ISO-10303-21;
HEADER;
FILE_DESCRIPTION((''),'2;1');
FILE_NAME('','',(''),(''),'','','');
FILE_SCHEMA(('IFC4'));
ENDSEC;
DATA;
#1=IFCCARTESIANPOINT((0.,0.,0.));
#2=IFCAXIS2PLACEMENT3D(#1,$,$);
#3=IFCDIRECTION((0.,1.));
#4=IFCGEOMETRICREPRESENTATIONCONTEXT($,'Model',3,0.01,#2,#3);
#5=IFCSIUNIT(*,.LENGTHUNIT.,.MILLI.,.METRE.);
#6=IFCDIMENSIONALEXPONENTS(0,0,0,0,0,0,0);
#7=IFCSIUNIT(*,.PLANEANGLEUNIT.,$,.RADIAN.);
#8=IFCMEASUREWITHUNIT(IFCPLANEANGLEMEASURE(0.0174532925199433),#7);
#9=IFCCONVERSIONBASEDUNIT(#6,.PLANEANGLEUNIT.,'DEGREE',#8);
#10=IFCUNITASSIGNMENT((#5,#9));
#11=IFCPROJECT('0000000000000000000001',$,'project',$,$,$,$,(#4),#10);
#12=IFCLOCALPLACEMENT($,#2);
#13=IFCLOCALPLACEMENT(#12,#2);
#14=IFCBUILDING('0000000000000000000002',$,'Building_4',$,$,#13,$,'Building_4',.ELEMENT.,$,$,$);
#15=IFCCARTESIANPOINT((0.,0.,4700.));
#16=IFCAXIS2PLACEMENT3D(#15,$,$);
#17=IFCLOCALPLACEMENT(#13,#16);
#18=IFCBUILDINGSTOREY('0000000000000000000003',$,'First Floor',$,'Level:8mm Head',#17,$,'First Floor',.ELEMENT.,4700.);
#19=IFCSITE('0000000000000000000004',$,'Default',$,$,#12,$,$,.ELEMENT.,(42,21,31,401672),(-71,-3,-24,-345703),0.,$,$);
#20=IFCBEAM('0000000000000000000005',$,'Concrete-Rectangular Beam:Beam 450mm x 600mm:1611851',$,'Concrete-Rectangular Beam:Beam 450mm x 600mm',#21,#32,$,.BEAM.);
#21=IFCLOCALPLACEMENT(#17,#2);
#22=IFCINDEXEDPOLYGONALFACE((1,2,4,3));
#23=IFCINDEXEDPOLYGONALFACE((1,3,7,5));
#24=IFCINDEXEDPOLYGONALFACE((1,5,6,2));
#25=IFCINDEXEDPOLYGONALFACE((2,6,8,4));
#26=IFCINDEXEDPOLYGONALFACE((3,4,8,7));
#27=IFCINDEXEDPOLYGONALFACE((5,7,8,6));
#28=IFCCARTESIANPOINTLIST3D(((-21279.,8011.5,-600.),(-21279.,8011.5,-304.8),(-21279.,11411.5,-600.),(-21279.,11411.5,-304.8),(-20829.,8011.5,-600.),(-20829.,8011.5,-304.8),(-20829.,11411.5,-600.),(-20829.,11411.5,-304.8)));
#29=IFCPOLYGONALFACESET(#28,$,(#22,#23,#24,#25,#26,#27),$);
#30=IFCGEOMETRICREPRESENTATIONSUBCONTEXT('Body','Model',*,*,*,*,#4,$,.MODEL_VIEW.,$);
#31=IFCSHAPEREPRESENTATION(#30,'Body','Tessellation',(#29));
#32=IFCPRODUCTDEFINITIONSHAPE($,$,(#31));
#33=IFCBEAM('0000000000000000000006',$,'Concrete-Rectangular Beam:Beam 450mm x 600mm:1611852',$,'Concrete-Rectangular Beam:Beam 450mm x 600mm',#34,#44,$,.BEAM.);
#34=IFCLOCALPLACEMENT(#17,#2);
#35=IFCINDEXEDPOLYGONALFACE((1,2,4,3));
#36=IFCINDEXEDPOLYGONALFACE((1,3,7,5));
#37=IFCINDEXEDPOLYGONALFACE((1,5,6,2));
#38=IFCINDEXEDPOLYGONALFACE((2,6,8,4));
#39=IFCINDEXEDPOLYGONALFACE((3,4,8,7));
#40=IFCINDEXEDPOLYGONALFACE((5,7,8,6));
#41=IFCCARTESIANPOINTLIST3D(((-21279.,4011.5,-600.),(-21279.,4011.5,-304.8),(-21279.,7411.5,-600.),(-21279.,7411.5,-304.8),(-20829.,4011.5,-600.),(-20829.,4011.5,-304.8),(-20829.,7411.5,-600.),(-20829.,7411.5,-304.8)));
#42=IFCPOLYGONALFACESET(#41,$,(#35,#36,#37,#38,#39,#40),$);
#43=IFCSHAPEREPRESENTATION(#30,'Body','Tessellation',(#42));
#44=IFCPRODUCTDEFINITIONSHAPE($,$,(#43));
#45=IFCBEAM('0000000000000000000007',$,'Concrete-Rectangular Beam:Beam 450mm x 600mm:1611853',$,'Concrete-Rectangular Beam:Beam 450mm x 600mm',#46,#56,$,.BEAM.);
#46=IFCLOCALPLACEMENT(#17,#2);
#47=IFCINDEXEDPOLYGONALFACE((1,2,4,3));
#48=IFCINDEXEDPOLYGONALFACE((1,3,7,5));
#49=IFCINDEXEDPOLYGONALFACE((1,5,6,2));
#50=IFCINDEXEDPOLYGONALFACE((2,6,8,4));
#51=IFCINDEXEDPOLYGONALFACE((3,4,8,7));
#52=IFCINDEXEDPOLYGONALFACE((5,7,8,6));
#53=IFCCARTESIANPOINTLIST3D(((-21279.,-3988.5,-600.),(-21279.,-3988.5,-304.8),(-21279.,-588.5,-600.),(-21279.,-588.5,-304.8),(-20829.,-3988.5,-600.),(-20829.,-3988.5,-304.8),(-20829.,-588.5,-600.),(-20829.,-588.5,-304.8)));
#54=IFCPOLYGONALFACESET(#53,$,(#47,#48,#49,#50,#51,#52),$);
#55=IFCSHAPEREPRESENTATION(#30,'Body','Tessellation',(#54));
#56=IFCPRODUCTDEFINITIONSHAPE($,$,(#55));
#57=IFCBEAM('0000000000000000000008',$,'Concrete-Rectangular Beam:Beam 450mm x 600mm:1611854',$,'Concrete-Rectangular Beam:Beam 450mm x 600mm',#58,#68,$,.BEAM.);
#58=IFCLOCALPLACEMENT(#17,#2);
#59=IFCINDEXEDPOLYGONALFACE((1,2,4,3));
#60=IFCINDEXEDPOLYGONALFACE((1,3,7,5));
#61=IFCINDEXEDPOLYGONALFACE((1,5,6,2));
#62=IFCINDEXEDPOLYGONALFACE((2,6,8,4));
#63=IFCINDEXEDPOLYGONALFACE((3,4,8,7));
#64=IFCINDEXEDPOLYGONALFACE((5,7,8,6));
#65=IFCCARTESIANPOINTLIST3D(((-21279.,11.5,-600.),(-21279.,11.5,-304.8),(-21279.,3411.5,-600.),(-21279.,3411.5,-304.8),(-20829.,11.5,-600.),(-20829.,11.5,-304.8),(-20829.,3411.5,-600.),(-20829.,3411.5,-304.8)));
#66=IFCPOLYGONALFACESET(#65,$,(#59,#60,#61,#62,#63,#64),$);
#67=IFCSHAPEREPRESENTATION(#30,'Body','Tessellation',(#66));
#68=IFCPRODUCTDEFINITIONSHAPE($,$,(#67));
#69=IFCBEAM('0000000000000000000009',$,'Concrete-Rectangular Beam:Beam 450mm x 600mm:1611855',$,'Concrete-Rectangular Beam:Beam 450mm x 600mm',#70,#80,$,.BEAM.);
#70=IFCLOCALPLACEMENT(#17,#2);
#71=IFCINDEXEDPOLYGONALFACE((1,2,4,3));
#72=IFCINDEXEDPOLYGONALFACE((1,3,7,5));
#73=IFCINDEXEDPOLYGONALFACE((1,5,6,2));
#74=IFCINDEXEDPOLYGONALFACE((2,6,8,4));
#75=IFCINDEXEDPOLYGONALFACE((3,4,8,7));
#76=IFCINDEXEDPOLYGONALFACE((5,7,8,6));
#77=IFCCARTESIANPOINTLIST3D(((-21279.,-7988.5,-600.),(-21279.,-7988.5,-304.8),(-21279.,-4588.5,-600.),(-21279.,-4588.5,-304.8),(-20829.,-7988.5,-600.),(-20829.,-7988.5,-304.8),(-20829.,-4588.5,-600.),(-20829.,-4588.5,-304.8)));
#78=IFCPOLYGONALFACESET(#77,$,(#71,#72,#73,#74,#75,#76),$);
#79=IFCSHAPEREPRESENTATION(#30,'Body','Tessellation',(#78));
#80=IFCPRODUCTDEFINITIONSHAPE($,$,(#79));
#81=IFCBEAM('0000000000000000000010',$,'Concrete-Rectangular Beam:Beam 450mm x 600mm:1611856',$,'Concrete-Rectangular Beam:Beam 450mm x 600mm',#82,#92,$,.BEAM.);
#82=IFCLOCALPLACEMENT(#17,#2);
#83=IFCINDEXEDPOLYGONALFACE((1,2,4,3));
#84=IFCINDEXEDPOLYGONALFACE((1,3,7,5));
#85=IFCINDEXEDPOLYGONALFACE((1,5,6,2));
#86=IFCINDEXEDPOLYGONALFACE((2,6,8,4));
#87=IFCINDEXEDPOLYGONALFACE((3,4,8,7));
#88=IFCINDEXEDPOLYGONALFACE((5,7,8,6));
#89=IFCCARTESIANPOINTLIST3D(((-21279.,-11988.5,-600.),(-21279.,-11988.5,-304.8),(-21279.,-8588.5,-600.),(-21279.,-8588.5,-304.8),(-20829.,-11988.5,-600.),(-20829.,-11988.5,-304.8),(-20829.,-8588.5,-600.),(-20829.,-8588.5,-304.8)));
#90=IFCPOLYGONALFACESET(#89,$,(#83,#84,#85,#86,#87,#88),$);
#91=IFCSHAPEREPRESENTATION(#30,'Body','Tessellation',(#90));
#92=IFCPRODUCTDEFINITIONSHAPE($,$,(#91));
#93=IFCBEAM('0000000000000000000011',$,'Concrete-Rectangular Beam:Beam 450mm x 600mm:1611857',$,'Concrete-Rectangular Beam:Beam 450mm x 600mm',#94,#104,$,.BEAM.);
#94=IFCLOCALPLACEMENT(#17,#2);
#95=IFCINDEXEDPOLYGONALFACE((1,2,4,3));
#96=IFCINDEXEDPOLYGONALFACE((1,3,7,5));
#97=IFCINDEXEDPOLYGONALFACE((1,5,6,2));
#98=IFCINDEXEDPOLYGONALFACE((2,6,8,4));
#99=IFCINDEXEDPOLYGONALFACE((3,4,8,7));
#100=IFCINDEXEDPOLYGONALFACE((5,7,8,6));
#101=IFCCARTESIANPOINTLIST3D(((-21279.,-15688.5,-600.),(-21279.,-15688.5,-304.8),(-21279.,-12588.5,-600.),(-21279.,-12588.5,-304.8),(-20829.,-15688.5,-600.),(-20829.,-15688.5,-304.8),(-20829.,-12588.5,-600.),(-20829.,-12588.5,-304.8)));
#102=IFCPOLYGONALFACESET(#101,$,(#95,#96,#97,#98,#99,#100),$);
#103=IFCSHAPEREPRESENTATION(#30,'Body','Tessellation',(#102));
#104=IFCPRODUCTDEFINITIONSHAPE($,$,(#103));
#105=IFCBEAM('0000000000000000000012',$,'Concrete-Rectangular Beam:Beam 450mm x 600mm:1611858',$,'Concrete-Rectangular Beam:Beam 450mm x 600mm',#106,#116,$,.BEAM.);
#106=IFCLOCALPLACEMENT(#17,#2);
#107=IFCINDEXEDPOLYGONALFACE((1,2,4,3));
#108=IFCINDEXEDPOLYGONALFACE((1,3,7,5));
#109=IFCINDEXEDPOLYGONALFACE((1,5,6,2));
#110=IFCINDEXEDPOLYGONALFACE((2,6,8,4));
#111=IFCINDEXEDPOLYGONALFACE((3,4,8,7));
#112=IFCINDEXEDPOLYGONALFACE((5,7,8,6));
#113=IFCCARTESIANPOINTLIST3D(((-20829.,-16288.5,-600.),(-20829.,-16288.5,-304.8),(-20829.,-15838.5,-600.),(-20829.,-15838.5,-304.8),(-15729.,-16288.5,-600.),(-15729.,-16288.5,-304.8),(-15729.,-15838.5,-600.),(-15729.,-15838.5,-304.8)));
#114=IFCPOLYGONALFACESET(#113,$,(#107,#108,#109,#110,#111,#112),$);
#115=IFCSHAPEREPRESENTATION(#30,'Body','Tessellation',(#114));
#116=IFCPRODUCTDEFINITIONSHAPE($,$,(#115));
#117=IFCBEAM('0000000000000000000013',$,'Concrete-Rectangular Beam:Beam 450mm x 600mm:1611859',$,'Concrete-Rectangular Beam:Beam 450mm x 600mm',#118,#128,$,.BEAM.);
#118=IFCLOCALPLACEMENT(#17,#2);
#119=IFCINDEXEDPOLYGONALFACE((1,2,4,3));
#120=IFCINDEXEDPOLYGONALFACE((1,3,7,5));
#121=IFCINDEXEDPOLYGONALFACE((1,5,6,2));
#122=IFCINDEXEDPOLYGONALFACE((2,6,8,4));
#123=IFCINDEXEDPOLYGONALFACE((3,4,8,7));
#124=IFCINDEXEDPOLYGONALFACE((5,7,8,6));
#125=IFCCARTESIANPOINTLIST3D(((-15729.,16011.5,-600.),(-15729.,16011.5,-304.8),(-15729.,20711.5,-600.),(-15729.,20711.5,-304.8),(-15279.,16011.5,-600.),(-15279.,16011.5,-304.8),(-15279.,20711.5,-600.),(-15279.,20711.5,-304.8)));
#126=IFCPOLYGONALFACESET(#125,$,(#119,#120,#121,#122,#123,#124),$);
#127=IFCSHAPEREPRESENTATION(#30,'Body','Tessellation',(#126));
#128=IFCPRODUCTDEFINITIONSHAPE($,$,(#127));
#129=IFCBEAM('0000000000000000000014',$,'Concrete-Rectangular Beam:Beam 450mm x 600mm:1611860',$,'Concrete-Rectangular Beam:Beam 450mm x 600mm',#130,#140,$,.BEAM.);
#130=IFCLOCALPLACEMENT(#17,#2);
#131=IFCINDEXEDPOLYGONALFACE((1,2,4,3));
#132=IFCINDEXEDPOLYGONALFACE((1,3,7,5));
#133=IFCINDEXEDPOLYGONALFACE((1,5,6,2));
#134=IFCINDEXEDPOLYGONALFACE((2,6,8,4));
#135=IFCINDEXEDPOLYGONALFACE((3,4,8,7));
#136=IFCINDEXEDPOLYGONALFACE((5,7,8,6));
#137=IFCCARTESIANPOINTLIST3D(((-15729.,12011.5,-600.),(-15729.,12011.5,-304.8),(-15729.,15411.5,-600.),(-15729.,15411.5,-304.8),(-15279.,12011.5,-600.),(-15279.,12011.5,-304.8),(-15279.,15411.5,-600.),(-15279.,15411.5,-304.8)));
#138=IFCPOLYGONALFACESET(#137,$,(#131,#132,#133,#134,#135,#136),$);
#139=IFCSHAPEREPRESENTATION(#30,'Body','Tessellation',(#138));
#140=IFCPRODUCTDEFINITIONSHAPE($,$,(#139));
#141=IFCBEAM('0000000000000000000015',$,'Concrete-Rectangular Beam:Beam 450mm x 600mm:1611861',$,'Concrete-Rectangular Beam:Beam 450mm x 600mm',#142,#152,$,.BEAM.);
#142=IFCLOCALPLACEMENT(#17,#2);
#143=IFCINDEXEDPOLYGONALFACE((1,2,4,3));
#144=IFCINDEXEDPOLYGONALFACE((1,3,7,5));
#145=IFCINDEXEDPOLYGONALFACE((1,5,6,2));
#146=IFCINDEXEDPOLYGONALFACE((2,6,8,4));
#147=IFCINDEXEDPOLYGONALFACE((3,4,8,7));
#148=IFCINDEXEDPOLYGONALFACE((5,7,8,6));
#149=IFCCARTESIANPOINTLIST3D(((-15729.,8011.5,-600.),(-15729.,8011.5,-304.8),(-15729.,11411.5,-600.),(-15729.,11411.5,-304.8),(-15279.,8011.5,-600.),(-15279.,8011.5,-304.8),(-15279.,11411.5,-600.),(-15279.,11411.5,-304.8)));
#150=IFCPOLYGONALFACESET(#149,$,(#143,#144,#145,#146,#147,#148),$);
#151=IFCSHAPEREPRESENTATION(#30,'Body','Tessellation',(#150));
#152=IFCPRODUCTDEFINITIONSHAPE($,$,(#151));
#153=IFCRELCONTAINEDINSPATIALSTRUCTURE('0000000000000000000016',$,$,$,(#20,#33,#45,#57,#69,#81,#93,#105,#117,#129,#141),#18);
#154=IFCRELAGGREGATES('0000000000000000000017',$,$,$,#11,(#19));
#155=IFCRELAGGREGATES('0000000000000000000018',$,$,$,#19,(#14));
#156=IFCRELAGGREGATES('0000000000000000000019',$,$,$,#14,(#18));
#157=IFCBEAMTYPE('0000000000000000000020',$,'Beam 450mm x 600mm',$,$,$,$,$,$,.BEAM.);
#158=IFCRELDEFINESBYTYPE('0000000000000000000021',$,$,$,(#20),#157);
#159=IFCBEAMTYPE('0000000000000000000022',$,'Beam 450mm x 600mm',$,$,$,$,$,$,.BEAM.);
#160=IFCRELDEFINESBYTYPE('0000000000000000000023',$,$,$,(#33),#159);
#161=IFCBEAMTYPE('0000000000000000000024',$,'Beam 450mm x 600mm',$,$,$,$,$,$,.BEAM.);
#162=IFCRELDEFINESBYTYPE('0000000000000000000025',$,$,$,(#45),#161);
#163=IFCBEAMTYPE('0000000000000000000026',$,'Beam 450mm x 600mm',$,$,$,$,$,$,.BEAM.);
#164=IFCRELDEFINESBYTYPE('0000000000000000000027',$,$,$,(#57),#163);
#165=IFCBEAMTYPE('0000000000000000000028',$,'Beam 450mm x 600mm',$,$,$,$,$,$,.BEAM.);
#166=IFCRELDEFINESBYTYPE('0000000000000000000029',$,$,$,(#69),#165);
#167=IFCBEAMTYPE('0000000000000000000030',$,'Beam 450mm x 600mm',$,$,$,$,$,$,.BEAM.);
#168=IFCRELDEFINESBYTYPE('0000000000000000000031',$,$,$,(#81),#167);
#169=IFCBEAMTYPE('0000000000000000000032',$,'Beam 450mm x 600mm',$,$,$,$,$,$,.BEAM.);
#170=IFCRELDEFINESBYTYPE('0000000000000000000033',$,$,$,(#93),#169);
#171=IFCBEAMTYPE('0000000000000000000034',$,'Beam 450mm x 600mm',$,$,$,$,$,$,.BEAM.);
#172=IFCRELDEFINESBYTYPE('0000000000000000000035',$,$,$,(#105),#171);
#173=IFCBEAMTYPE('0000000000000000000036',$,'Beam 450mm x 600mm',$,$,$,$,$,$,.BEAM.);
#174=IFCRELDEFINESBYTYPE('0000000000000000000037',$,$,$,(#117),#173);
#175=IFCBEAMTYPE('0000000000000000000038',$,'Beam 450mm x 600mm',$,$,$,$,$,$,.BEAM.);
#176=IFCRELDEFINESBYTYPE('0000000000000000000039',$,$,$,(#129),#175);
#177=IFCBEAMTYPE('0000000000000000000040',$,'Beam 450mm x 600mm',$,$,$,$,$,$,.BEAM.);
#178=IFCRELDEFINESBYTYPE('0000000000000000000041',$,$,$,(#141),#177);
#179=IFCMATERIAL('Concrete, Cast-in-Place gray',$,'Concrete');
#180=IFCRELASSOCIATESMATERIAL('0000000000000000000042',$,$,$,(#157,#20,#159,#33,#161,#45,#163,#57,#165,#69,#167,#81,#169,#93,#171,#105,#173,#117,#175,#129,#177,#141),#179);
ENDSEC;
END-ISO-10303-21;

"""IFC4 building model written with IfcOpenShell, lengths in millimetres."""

from ifc_helpers import new_model, entity, si_unit, converted_unit, direction, frame, origin, place, context, subcontext, project, spatial, indexed_curve, outline, extrude, source, transform, mapped, material, type_object, type_shapes, element, save


model = new_model("IFC4")

# Units and contexts
model_context = context("Model", 3, precision=0.01, world=origin(), true_north=direction((0.0, 1.0)))
body_context = subcontext(model_context, "Body", "Model", "MODEL_VIEW")
ifc_project = project(units=[si_unit("LENGTHUNIT", "METRE", prefix="MILLI"), converted_unit("PLANEANGLEUNIT", "DEGREE", entity("IfcPlaneAngleMeasure", 0.0174532925199433), si_unit("PLANEANGLEUNIT", "RADIAN"), dimensions=[0, 0, 0, 0, 0, 0, 0])], contexts=[model_context])

# Site, building, storey
site_placement = place(None, origin())
site = spatial("IfcSite", under=ifc_project, at=site_placement, Name="Default", CompositionType="ELEMENT", RefLatitude=(42, 21, 31, 401672), RefLongitude=(-71, -3, -24, -345703), RefElevation=0.0)
building_placement = place(site_placement, origin())
building = spatial("IfcBuilding", under=site, at=building_placement, Name="Building_4", LongName="Building_4", CompositionType="ELEMENT")
storey_placement = place(building_placement, frame((0.0, 0.0, 4700.0)))
storey = spatial("IfcBuildingStorey", under=building, at=storey_placement, Name="First Floor", ObjectType="Level:8mm Head", LongName="First Floor", CompositionType="ELEMENT", Elevation=4700.0)

# Beams
ifc_material = material(Name="Concrete, Cast-in-Place gray", Category="Concrete")
beam_type_1 = type_object("IfcBeamType", Name="Beam 450mm x 600mm", PredefinedType="BEAM", material=ifc_material)
shared_shape_1 = source(origin(), body_context, "Body", "SweptSolid", [
    extrude(outline(indexed_curve([(-225.0, -147.6), (225.0, -147.6), (225.0, 147.6), (-225.0, 147.6), (-225.0, -147.6)], self_intersect=False)), frame((-21054.0, 8011.5, 4247.6), z_axis=(0.0, 1.0, 0.0), x_axis=(-1.0, 0.0, 0.0)), (0.0, 0.0, 1.0), 3400.0),
])
type_shapes(beam_type_1, [shared_shape_1])
beam_1_placement = place(storey_placement, frame((0.0, 0.0, -4700.0)))
element("IfcBeam", 1, at=beam_1_placement, inside=storey, type_object=beam_type_1, material=ifc_material, Name="Concrete-Rectangular Beam:Beam 450mm x 600mm:1611851", ObjectType="Concrete-Rectangular Beam:Beam 450mm x 600mm", PredefinedType="BEAM", context=body_context, shape_type="MappedRepresentation", body=[
    mapped(shared_shape_1, transform((0.0, 0.0, 0.0), scale=1.0)),
])
beam_type_2 = type_object("IfcBeamType", Name="Beam 450mm x 600mm", PredefinedType="BEAM", material=ifc_material)
shared_shape_2 = source(origin(), body_context, "Body", "SweptSolid", [
    extrude(outline(indexed_curve([(-225.0, -147.6), (225.0, -147.6), (225.0, 147.6), (-225.0, 147.6), (-225.0, -147.6)], self_intersect=False)), frame((-21054.0, 4011.5, 4247.6), z_axis=(0.0, 1.0, 0.0), x_axis=(-1.0, 0.0, 0.0)), (0.0, 0.0, 1.0), 3400.0),
])
type_shapes(beam_type_2, [shared_shape_2])
beam_2_placement = place(storey_placement, frame((0.0, 0.0, -4700.0)))
element("IfcBeam", 2, at=beam_2_placement, inside=storey, type_object=beam_type_2, material=ifc_material, Name="Concrete-Rectangular Beam:Beam 450mm x 600mm:1611852", ObjectType="Concrete-Rectangular Beam:Beam 450mm x 600mm", PredefinedType="BEAM", context=body_context, shape_type="MappedRepresentation", body=[
    mapped(shared_shape_2, transform((0.0, 0.0, 0.0), scale=1.0)),
])
beam_type_3 = type_object("IfcBeamType", Name="Beam 450mm x 600mm", PredefinedType="BEAM", material=ifc_material)
shared_shape_3 = source(origin(), body_context, "Body", "SweptSolid", [
    extrude(outline(indexed_curve([(-225.0, -147.6), (225.0, -147.6), (225.0, 147.6), (-225.0, 147.6), (-225.0, -147.6)], self_intersect=False)), frame((-21054.0, -588.5, 4247.6), z_axis=(0.0, -1.0, 0.0), x_axis=(-1.0, 0.0, 0.0)), (0.0, 0.0, 1.0), 3400.0),
])
type_shapes(beam_type_3, [shared_shape_3])
beam_3_placement = place(storey_placement, frame((0.0, 0.0, -4700.0)))
element("IfcBeam", 3, at=beam_3_placement, inside=storey, type_object=beam_type_3, material=ifc_material, Name="Concrete-Rectangular Beam:Beam 450mm x 600mm:1611853", ObjectType="Concrete-Rectangular Beam:Beam 450mm x 600mm", PredefinedType="BEAM", context=body_context, shape_type="MappedRepresentation", body=[
    mapped(shared_shape_3, transform((0.0, 0.0, 0.0), scale=1.0)),
])
beam_type_4 = type_object("IfcBeamType", Name="Beam 450mm x 600mm", PredefinedType="BEAM", material=ifc_material)
shared_shape_4 = source(origin(), body_context, "Body", "SweptSolid", [
    extrude(outline(indexed_curve([(-225.0, -147.6), (225.0, -147.6), (225.0, 147.6), (-225.0, 147.6), (-225.0, -147.6)], self_intersect=False)), frame((-21054.0, 11.5, 4247.6), z_axis=(0.0, 1.0, 0.0), x_axis=(-1.0, 0.0, 0.0)), (0.0, 0.0, 1.0), 3400.0),
])
type_shapes(beam_type_4, [shared_shape_4])
beam_4_placement = place(storey_placement, frame((0.0, 0.0, -4700.0)))
element("IfcBeam", 4, at=beam_4_placement, inside=storey, type_object=beam_type_4, material=ifc_material, Name="Concrete-Rectangular Beam:Beam 450mm x 600mm:1611854", ObjectType="Concrete-Rectangular Beam:Beam 450mm x 600mm", PredefinedType="BEAM", context=body_context, shape_type="MappedRepresentation", body=[
    mapped(shared_shape_4, transform((0.0, 0.0, 0.0), scale=1.0)),
])
beam_type_5 = type_object("IfcBeamType", Name="Beam 450mm x 600mm", PredefinedType="BEAM", material=ifc_material)
shared_shape_5 = source(origin(), body_context, "Body", "SweptSolid", [
    extrude(outline(indexed_curve([(-225.0, -147.6), (225.0, -147.6), (225.0, 147.6), (-225.0, 147.6), (-225.0, -147.6)], self_intersect=False)), frame((-21054.0, -4588.5, 4247.6), z_axis=(0.0, -1.0, 0.0), x_axis=(-1.0, 0.0, 0.0)), (0.0, 0.0, 1.0), 3400.0),
])
type_shapes(beam_type_5, [shared_shape_5])
beam_5_placement = place(storey_placement, frame((0.0, 0.0, -4700.0)))
element("IfcBeam", 5, at=beam_5_placement, inside=storey, type_object=beam_type_5, material=ifc_material, Name="Concrete-Rectangular Beam:Beam 450mm x 600mm:1611855", ObjectType="Concrete-Rectangular Beam:Beam 450mm x 600mm", PredefinedType="BEAM", context=body_context, shape_type="MappedRepresentation", body=[
    mapped(shared_shape_5, transform((0.0, 0.0, 0.0), scale=1.0)),
])
beam_type_6 = type_object("IfcBeamType", Name="Beam 450mm x 600mm", PredefinedType="BEAM", material=ifc_material)
shared_shape_6 = source(origin(), body_context, "Body", "SweptSolid", [
    extrude(outline(indexed_curve([(-225.0, -147.6), (225.0, -147.6), (225.0, 147.6), (-225.0, 147.6), (-225.0, -147.6)], self_intersect=False)), frame((-21054.0, -8588.5, 4247.6), z_axis=(0.0, -1.0, 0.0), x_axis=(-1.0, 0.0, 0.0)), (0.0, 0.0, 1.0), 3400.0),
])
type_shapes(beam_type_6, [shared_shape_6])
beam_6_placement = place(storey_placement, frame((0.0, 0.0, -4700.0)))
element("IfcBeam", 6, at=beam_6_placement, inside=storey, type_object=beam_type_6, material=ifc_material, Name="Concrete-Rectangular Beam:Beam 450mm x 600mm:1611856", ObjectType="Concrete-Rectangular Beam:Beam 450mm x 600mm", PredefinedType="BEAM", context=body_context, shape_type="MappedRepresentation", body=[
    mapped(shared_shape_6, transform((0.0, 0.0, 0.0), scale=1.0)),
])
beam_type_7 = type_object("IfcBeamType", Name="Beam 450mm x 600mm", PredefinedType="BEAM", material=ifc_material)
shared_shape_7 = source(origin(), body_context, "Body", "SweptSolid", [
    extrude(outline(indexed_curve([(-225.0, -147.6), (225.0, -147.6), (225.0, 147.6), (-225.0, 147.6), (-225.0, -147.6)], self_intersect=False)), frame((-21054.0, -12588.5, 4247.6), z_axis=(0.0, -1.0, 0.0), x_axis=(-1.0, 0.0, 0.0)), (0.0, 0.0, 1.0), 3100.0),
])
type_shapes(beam_type_7, [shared_shape_7])
beam_7_placement = place(storey_placement, frame((0.0, 0.0, -4700.0)))
element("IfcBeam", 7, at=beam_7_placement, inside=storey, type_object=beam_type_7, material=ifc_material, Name="Concrete-Rectangular Beam:Beam 450mm x 600mm:1611857", ObjectType="Concrete-Rectangular Beam:Beam 450mm x 600mm", PredefinedType="BEAM", context=body_context, shape_type="MappedRepresentation", body=[
    mapped(shared_shape_7, transform((0.0, 0.0, 0.0), scale=1.0)),
])
beam_type_8 = type_object("IfcBeamType", Name="Beam 450mm x 600mm", PredefinedType="BEAM", material=ifc_material)
shared_shape_8 = source(origin(), body_context, "Body", "SweptSolid", [
    extrude(outline(indexed_curve([(-147.6, -225.0), (147.6, -225.0), (147.6, 225.0), (-147.6, 225.0), (-147.6, -225.0)], self_intersect=False)), frame((-15729.0, -16063.5, 4247.6), z_axis=(-1.0, 0.0, 0.0), x_axis=(0.0, 0.0, -1.0)), (0.0, 0.0, 1.0), 5100.0),
])
type_shapes(beam_type_8, [shared_shape_8])
beam_8_placement = place(storey_placement, frame((0.0, 0.0, -4700.0)))
element("IfcBeam", 8, at=beam_8_placement, inside=storey, type_object=beam_type_8, material=ifc_material, Name="Concrete-Rectangular Beam:Beam 450mm x 600mm:1611858", ObjectType="Concrete-Rectangular Beam:Beam 450mm x 600mm", PredefinedType="BEAM", context=body_context, shape_type="MappedRepresentation", body=[
    mapped(shared_shape_8, transform((0.0, 0.0, 0.0), scale=1.0)),
])
beam_type_9 = type_object("IfcBeamType", Name="Beam 450mm x 600mm", PredefinedType="BEAM", material=ifc_material)
shared_shape_9 = source(origin(), body_context, "Body", "SweptSolid", [
    extrude(outline(indexed_curve([(-225.0, -147.6), (225.0, -147.6), (225.0, 147.6), (-225.0, 147.6), (-225.0, -147.6)], self_intersect=False)), frame((-15504.0, 16011.5, 4247.6), z_axis=(0.0, 1.0, 0.0), x_axis=(-1.0, 0.0, 0.0)), (0.0, 0.0, 1.0), 4700.0),
])
type_shapes(beam_type_9, [shared_shape_9])
beam_9_placement = place(storey_placement, frame((0.0, 0.0, -4700.0)))
element("IfcBeam", 9, at=beam_9_placement, inside=storey, type_object=beam_type_9, material=ifc_material, Name="Concrete-Rectangular Beam:Beam 450mm x 600mm:1611859", ObjectType="Concrete-Rectangular Beam:Beam 450mm x 600mm", PredefinedType="BEAM", context=body_context, shape_type="MappedRepresentation", body=[
    mapped(shared_shape_9, transform((0.0, 0.0, 0.0), scale=1.0)),
])
beam_type_10 = type_object("IfcBeamType", Name="Beam 450mm x 600mm", PredefinedType="BEAM", material=ifc_material)
shared_shape_10 = source(origin(), body_context, "Body", "SweptSolid", [
    extrude(outline(indexed_curve([(-225.0, -147.6), (225.0, -147.6), (225.0, 147.6), (-225.0, 147.6), (-225.0, -147.6)], self_intersect=False)), frame((-15504.0, 12011.5, 4247.6), z_axis=(0.0, 1.0, 0.0), x_axis=(-1.0, 0.0, 0.0)), (0.0, 0.0, 1.0), 3400.0),
])
type_shapes(beam_type_10, [shared_shape_10])
beam_10_placement = place(storey_placement, frame((0.0, 0.0, -4700.0)))
element("IfcBeam", 10, at=beam_10_placement, inside=storey, type_object=beam_type_10, material=ifc_material, Name="Concrete-Rectangular Beam:Beam 450mm x 600mm:1611860", ObjectType="Concrete-Rectangular Beam:Beam 450mm x 600mm", PredefinedType="BEAM", context=body_context, shape_type="MappedRepresentation", body=[
    mapped(shared_shape_10, transform((0.0, 0.0, 0.0), scale=1.0)),
])
beam_type_11 = type_object("IfcBeamType", Name="Beam 450mm x 600mm", PredefinedType="BEAM", material=ifc_material)
shared_shape_11 = source(origin(), body_context, "Body", "SweptSolid", [
    extrude(outline(indexed_curve([(-225.0, -147.6), (225.0, -147.6), (225.0, 147.6), (-225.0, 147.6), (-225.0, -147.6)], self_intersect=False)), frame((-15504.0, 8011.5, 4247.6), z_axis=(0.0, 1.0, 0.0), x_axis=(-1.0, 0.0, 0.0)), (0.0, 0.0, 1.0), 3400.0),
])
type_shapes(beam_type_11, [shared_shape_11])
beam_11_placement = place(storey_placement, frame((0.0, 0.0, -4700.0)))
element("IfcBeam", 11, at=beam_11_placement, inside=storey, type_object=beam_type_11, material=ifc_material, Name="Concrete-Rectangular Beam:Beam 450mm x 600mm:1611861", ObjectType="Concrete-Rectangular Beam:Beam 450mm x 600mm", PredefinedType="BEAM", context=body_context, shape_type="MappedRepresentation", body=[
    mapped(shared_shape_11, transform((0.0, 0.0, 0.0), scale=1.0)),
])

save(model, "model.ifc")
